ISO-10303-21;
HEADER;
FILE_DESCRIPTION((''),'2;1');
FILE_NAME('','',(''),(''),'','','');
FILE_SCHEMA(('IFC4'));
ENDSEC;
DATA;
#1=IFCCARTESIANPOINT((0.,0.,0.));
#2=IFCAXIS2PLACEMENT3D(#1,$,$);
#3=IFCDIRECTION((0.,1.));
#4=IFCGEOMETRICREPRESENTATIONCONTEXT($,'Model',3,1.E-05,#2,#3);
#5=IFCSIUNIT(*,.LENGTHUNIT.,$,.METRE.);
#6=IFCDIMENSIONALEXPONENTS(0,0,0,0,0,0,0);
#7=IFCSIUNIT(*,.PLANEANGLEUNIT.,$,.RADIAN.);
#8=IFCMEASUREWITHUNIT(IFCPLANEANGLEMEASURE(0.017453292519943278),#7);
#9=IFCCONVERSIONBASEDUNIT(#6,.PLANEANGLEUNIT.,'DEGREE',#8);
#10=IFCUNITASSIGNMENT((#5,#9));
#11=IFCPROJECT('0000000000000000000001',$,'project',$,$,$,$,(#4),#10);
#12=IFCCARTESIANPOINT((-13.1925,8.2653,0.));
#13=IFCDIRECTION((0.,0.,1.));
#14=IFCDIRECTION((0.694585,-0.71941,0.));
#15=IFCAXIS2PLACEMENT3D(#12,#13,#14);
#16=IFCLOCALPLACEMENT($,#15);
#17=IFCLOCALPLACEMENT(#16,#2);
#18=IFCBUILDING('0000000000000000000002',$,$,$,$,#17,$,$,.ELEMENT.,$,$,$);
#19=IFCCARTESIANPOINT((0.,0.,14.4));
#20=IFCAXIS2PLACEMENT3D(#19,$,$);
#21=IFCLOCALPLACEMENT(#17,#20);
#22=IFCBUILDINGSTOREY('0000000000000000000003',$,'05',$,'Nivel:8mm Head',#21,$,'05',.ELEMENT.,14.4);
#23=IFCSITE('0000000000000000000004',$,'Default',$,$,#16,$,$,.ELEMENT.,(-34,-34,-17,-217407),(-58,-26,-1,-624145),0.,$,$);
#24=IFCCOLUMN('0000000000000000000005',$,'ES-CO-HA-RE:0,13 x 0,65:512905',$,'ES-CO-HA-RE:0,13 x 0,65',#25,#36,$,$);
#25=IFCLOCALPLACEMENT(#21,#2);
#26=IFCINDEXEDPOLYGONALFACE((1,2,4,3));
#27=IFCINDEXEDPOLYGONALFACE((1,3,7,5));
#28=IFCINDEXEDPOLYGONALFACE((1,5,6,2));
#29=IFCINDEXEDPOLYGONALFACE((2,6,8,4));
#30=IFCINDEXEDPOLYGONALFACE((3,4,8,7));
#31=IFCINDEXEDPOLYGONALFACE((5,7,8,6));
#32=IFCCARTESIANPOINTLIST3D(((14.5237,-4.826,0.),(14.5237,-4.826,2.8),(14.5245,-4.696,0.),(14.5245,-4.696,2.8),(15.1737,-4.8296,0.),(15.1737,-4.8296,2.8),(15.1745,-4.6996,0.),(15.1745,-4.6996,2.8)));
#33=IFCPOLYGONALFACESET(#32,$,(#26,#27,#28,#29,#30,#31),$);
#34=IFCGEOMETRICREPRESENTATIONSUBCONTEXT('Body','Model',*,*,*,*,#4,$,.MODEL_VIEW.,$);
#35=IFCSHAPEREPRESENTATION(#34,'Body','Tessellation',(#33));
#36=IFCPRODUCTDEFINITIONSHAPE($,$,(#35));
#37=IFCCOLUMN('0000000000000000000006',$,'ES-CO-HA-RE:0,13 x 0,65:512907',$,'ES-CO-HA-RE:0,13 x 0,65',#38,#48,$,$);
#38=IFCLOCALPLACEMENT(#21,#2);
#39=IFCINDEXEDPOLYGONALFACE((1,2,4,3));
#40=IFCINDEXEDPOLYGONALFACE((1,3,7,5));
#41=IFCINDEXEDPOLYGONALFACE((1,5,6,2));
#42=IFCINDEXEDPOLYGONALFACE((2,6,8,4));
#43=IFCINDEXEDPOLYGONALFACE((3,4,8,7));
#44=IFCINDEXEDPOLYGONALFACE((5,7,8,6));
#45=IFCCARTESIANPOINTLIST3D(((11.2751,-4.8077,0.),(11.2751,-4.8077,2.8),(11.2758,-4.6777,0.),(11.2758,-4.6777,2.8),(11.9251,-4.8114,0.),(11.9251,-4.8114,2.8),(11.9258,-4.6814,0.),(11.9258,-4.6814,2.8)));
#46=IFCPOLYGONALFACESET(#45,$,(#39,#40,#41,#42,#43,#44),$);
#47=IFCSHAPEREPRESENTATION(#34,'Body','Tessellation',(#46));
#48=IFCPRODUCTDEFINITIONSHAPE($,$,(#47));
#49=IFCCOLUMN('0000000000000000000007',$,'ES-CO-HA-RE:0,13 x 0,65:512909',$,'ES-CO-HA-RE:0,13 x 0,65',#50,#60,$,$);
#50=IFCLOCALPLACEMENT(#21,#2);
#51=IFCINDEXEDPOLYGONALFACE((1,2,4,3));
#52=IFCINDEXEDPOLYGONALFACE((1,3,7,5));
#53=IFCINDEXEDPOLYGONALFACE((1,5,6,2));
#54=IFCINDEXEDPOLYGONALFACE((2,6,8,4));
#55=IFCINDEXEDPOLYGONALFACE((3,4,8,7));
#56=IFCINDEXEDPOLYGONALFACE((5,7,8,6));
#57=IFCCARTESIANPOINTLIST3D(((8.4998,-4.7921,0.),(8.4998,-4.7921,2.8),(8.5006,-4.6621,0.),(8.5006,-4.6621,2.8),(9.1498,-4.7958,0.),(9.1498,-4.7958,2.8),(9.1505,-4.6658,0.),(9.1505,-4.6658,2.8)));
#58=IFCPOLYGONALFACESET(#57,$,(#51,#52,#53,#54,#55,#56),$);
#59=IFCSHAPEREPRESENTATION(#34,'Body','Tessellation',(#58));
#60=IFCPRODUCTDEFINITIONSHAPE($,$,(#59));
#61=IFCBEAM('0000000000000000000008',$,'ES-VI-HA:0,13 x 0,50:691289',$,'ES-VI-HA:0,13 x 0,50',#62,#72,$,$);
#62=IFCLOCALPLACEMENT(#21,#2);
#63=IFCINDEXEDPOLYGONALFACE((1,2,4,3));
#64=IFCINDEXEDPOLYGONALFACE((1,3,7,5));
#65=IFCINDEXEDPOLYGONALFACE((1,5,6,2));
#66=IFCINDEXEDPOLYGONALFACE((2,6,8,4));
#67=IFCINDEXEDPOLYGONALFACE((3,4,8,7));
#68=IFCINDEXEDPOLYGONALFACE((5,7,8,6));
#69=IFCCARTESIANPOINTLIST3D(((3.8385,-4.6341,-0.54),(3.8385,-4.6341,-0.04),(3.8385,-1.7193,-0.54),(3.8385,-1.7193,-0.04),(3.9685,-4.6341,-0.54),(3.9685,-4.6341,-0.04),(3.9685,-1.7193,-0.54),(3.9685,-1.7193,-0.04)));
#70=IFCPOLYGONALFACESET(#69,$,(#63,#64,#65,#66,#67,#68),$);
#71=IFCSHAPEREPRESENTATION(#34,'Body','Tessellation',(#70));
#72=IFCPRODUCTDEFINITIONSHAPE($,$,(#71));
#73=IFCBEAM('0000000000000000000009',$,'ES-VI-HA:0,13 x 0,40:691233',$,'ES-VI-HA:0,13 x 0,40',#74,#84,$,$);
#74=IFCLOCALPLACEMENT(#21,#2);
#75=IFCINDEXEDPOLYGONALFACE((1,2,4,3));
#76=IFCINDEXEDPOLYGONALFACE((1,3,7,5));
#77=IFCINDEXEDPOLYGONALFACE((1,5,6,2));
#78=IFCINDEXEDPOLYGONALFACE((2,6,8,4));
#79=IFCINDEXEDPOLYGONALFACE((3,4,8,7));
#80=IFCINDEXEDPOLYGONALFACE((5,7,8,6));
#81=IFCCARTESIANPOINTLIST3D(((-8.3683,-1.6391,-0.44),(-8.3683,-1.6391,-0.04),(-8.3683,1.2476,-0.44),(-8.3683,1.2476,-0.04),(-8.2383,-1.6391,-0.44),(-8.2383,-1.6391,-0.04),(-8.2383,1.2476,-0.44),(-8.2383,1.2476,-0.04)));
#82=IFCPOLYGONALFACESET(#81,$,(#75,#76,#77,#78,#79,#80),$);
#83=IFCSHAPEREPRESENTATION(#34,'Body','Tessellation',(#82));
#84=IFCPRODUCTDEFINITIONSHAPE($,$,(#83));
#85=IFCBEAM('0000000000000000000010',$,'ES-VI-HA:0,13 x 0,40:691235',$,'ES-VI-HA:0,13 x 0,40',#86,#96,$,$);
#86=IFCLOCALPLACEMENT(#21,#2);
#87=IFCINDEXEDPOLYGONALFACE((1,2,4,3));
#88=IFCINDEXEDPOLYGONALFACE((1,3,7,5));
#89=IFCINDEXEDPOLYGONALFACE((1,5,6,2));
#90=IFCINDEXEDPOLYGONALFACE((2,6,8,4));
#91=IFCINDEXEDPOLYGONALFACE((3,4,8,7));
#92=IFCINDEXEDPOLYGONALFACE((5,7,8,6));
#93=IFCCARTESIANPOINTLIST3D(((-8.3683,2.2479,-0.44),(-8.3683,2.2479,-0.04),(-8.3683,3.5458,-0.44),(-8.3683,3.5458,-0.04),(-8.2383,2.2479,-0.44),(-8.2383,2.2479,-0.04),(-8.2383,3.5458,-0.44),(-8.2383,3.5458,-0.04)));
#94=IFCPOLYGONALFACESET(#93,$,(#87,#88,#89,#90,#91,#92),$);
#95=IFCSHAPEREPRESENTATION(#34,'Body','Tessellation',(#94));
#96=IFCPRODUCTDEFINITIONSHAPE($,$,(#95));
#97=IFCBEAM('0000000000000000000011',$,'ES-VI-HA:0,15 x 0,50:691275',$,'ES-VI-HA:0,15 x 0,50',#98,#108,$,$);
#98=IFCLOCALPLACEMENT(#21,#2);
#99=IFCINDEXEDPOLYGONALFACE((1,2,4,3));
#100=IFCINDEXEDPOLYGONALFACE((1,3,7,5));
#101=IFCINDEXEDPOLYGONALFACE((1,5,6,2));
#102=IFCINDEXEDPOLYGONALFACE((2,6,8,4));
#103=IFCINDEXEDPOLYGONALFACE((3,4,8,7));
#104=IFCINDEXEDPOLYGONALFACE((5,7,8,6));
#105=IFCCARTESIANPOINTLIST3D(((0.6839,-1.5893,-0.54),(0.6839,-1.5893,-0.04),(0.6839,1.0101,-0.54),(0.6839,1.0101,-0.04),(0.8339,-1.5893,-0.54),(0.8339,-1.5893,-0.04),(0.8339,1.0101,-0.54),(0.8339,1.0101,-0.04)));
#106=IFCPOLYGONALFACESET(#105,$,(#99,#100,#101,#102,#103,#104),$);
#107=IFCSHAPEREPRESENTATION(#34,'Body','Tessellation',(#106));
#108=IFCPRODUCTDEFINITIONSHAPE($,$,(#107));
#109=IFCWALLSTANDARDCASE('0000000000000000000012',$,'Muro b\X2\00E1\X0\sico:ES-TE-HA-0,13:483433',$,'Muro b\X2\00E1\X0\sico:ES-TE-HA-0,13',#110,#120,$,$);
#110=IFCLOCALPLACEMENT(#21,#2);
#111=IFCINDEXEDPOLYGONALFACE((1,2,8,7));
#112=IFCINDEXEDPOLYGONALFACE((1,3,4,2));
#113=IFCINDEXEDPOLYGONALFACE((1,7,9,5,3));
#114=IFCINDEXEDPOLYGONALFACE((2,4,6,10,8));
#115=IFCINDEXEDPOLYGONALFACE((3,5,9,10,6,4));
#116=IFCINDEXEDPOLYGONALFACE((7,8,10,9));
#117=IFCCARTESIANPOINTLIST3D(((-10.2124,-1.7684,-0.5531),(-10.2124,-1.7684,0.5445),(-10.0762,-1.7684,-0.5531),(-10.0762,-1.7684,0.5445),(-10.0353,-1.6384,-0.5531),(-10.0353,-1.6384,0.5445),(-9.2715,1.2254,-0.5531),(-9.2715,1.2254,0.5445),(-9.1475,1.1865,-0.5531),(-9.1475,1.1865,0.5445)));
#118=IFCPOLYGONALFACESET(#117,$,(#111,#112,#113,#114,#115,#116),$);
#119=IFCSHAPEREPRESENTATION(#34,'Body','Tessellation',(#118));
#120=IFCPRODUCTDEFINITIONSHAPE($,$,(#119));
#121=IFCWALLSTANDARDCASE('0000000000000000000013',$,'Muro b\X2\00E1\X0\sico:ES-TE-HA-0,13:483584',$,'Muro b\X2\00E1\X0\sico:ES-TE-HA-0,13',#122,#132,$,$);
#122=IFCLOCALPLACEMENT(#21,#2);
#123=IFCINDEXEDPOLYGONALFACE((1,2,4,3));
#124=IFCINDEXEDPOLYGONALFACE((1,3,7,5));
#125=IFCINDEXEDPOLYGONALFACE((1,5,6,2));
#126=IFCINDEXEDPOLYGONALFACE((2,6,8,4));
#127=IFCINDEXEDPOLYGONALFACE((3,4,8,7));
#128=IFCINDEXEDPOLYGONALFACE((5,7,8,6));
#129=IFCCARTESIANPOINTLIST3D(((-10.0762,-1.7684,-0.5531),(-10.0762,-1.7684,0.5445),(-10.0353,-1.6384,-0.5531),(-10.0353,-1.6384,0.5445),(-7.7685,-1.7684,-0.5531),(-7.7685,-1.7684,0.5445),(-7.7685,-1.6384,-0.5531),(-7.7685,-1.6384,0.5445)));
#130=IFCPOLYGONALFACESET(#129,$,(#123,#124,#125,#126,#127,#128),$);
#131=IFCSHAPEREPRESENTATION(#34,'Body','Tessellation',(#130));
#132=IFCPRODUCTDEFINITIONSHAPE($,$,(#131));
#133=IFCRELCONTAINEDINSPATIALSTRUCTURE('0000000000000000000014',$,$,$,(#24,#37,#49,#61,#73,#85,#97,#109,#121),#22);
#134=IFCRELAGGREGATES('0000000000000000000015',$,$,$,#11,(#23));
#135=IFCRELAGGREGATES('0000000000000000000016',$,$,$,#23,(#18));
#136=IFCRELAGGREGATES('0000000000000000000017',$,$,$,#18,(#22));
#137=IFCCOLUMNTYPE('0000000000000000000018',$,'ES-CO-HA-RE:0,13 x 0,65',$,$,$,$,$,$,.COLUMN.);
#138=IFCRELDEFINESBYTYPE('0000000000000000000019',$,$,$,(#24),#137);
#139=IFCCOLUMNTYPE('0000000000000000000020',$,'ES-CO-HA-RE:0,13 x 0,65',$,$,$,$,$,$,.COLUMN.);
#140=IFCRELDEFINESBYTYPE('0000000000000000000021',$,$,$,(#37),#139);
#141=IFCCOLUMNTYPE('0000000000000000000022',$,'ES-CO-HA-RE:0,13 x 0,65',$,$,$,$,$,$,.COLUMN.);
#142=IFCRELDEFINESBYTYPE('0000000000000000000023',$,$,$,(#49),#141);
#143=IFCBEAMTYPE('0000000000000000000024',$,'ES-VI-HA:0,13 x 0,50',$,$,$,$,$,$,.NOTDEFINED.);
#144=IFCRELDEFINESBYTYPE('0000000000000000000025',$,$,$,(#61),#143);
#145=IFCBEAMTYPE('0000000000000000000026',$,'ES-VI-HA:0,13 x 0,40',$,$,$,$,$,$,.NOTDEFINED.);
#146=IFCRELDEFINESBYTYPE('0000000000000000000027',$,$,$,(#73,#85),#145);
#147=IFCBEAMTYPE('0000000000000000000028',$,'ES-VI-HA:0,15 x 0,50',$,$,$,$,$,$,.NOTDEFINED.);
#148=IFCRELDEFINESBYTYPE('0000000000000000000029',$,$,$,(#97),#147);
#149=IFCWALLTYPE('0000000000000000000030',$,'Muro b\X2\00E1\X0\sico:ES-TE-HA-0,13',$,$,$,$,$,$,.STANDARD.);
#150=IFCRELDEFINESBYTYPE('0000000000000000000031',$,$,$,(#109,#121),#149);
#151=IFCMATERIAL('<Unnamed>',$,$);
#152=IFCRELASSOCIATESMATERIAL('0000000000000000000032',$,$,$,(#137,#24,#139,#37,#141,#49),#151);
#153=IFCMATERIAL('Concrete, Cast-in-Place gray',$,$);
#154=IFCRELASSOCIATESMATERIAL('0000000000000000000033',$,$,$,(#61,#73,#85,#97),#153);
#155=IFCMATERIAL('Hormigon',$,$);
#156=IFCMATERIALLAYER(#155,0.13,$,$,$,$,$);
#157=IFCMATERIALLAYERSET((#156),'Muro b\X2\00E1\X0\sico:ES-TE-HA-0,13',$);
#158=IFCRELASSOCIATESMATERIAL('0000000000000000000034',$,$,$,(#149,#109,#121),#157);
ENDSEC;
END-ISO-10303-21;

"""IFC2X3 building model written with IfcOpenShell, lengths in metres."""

from ifc_helpers import new_model, entity, si_unit, converted_unit, direction, frame, frame_2d, origin, origin_2d_with_axis, place, context, subcontext, project, spatial, polyline, rectangle, outline, extrude, source, transform, mapped, material, layer, layer_set, layer_usage, type_object, type_shapes, element, save


model = new_model("IFC2X3")

# Units and contexts
model_context = context("Model", 3, precision=1e-05, world=origin(), true_north=direction((0.0, 1.0)))
body_context = subcontext(model_context, "Body", "Model", "MODEL_VIEW")
ifc_project = project(units=[si_unit("LENGTHUNIT", "METRE"), converted_unit("PLANEANGLEUNIT", "DEGREE", entity("IfcPlaneAngleMeasure", 0.017453292519943278), si_unit("PLANEANGLEUNIT", "RADIAN"), dimensions=[0, 0, 0, 0, 0, 0, 0])], contexts=[model_context])

# Site, building, storey
site_placement = place(None, frame((-13.1925, 8.2653, 0.0), z_axis=(0.0, 0.0, 1.0), x_axis=(0.694585, -0.71941, 0.0)))
site = spatial("IfcSite", under=ifc_project, at=site_placement, Name="Default", CompositionType="ELEMENT", RefLatitude=(-34, -34, -17, -217407), RefLongitude=(-58, -26, -1, -624145), RefElevation=0.0)
building_placement = place(site_placement, origin())
building = spatial("IfcBuilding", under=site, at=building_placement, CompositionType="ELEMENT")
storey_placement = place(building_placement, frame((0.0, 0.0, 14.4)))
storey = spatial("IfcBuildingStorey", under=building, at=storey_placement, Name="05", ObjectType="Nivel:8mm Head", LongName="05", CompositionType="ELEMENT", Elevation=14.4)

# Columns
ifc_material_1 = material(Name="<Unnamed>")
column_type_1 = type_object("IfcColumnType", Name="ES-CO-HA-RE:0,13 x 0,65", PredefinedType="COLUMN", material=ifc_material_1)
shared_shape_1 = source(origin(), body_context, "Body", "SweptSolid", [
    extrude(rectangle(XDim=0.65, YDim=0.13, at=frame_2d((0.0, 0.0), x_axis=(1.0, 0.0))), frame((14.8491, -4.7628, 14.4), z_axis=(0.0, 0.0, 1.0), x_axis=(-0.999984, 0.005619, 0.0)), (0.0, 0.0, 1.0), 2.8),
])
type_shapes(column_type_1, [shared_shape_1])
column_1_placement = place(storey_placement, frame((0.0, 0.0, -14.4)))
element("IfcColumn", 1, at=column_1_placement, inside=storey, type_object=column_type_1, material=ifc_material_1, Name="ES-CO-HA-RE:0,13 x 0,65:512905", ObjectType="ES-CO-HA-RE:0,13 x 0,65", context=body_context, shape_type="MappedRepresentation", body=[
    mapped(shared_shape_1, transform((0.0, 0.0, 0.0), scale=1.0)),
])
column_type_2 = type_object("IfcColumnType", Name="ES-CO-HA-RE:0,13 x 0,65", PredefinedType="COLUMN", material=ifc_material_1)
shared_shape_2 = source(origin(), body_context, "Body", "SweptSolid", [
    extrude(rectangle(XDim=0.65, YDim=0.13, at=frame_2d((0.0, 0.0), x_axis=(1.0, 0.0))), frame((11.6005, -4.7445, 14.4), z_axis=(0.0, 0.0, 1.0), x_axis=(-0.999984, 0.005619, 0.0)), (0.0, 0.0, 1.0), 2.8),
])
type_shapes(column_type_2, [shared_shape_2])
column_2_placement = place(storey_placement, frame((0.0, 0.0, -14.4)))
element("IfcColumn", 2, at=column_2_placement, inside=storey, type_object=column_type_2, material=ifc_material_1, Name="ES-CO-HA-RE:0,13 x 0,65:512907", ObjectType="ES-CO-HA-RE:0,13 x 0,65", context=body_context, shape_type="MappedRepresentation", body=[
    mapped(shared_shape_2, transform((0.0, 0.0, 0.0), scale=1.0)),
])
column_type_3 = type_object("IfcColumnType", Name="ES-CO-HA-RE:0,13 x 0,65", PredefinedType="COLUMN", material=ifc_material_1)
shared_shape_3 = source(origin(), body_context, "Body", "SweptSolid", [
    extrude(rectangle(XDim=0.65, YDim=0.13, at=origin_2d_with_axis()), frame((8.8252, -4.7289, 14.4), z_axis=(0.0, 0.0, 1.0), x_axis=(-0.999984, 0.005619, 0.0)), (0.0, 0.0, 1.0), 2.8),
])
type_shapes(column_type_3, [shared_shape_3])
column_3_placement = place(storey_placement, frame((0.0, 0.0, -14.4)))
element("IfcColumn", 3, at=column_3_placement, inside=storey, type_object=column_type_3, material=ifc_material_1, Name="ES-CO-HA-RE:0,13 x 0,65:512909", ObjectType="ES-CO-HA-RE:0,13 x 0,65", context=body_context, shape_type="MappedRepresentation", body=[
    mapped(shared_shape_3, transform((0.0, 0.0, 0.0), scale=1.0)),
])

# Beams
ifc_material_2 = material(Name="Concrete, Cast-in-Place gray")
beam_type_1 = type_object("IfcBeamType", Name="ES-VI-HA:0,13 x 0,50", PredefinedType="NOTDEFINED")
beam_1_placement = place(storey_placement, frame((3.9035, -4.7011, -0.04), z_axis=(0.0, 0.0, 1.0), x_axis=(0.0, 1.0, 0.0)))
element("IfcBeam", 4, at=beam_1_placement, inside=storey, type_object=beam_type_1, material=ifc_material_2, Name="ES-VI-HA:0,13 x 0,50:691289", ObjectType="ES-VI-HA:0,13 x 0,50", context=body_context, shape_type="SweptSolid", body=[
    extrude(rectangle(XDim=0.5, YDim=0.13, at=frame_2d((0.0, 0.0), x_axis=(1.0, 0.0))), frame((0.067, 0.0, -0.25), z_axis=(1.0, 0.0, 0.0), x_axis=(0.0, 0.0, -1.0)), (0.0, 0.0, 1.0), 2.9148),
])
beam_type_2 = type_object("IfcBeamType", Name="ES-VI-HA:0,13 x 0,40", PredefinedType="NOTDEFINED")
beam_2_placement = place(storey_placement, frame((-8.3033, -1.6391, -0.04), z_axis=(0.0, 0.0, 1.0), x_axis=(0.0, 1.0, 0.0)))
element("IfcBeam", 5, at=beam_2_placement, inside=storey, type_object=beam_type_2, material=ifc_material_2, Name="ES-VI-HA:0,13 x 0,40:691233", ObjectType="ES-VI-HA:0,13 x 0,40", context=body_context, shape_type="SweptSolid", body=[
    extrude(rectangle(XDim=0.4, YDim=0.13, at=frame_2d((0.0, 0.0), x_axis=(1.0, 0.0))), frame((0.0, 0.0, -0.2), z_axis=(1.0, 0.0, 0.0), x_axis=(0.0, 0.0, -1.0)), (0.0, 0.0, 1.0), 2.8867),
])
beam_3_placement = place(storey_placement, frame((-8.3033, 2.2479, -0.04), z_axis=(0.0, 0.0, 1.0), x_axis=(0.0, 1.0, 0.0)))
element("IfcBeam", 6, at=beam_3_placement, inside=storey, type_object=beam_type_2, material=ifc_material_2, Name="ES-VI-HA:0,13 x 0,40:691235", ObjectType="ES-VI-HA:0,13 x 0,40", context=body_context, shape_type="SweptSolid", body=[
    extrude(rectangle(XDim=0.4, YDim=0.13, at=frame_2d((0.0, 0.0), x_axis=(1.0, 0.0))), frame((0.0, 0.0, -0.2), z_axis=(1.0, 0.0, 0.0), x_axis=(0.0, 0.0, -1.0)), (0.0, 0.0, 1.0), 1.298),
])
beam_type_3 = type_object("IfcBeamType", Name="ES-VI-HA:0,15 x 0,50", PredefinedType="NOTDEFINED")
beam_4_placement = place(storey_placement, frame((0.7589, -1.6543, -0.04), z_axis=(0.0, 0.0, 1.0), x_axis=(0.0, 1.0, 0.0)))
element("IfcBeam", 7, at=beam_4_placement, inside=storey, type_object=beam_type_3, material=ifc_material_2, Name="ES-VI-HA:0,15 x 0,50:691275", ObjectType="ES-VI-HA:0,15 x 0,50", context=body_context, shape_type="SweptSolid", body=[
    extrude(rectangle(XDim=0.5, YDim=0.15, at=frame_2d((0.0, 0.0), x_axis=(1.0, 0.0))), frame((0.065, 0.0, -0.25), z_axis=(1.0, 0.0, 0.0), x_axis=(0.0, 0.0, -1.0)), (0.0, 0.0, 1.0), 2.5994),
])

# Shared definitions
ifc_material_3 = material(Name="Hormigon")

# Walls
ifc_layer_1 = layer(ifc_material_3, 0.13)
ifc_layer_set_1 = layer_set([ifc_layer_1], Name="Muro básico:ES-TE-HA-0,13")
ifc_layer_usage_1 = layer_usage(ifc_layer_set_1, "AXIS2", "NEGATIVE", 0.065)
wall_type = type_object("IfcWallType", Name="Muro básico:ES-TE-HA-0,13", PredefinedType="STANDARD", material=ifc_layer_set_1)
wall_1_placement = place(storey_placement, frame((-10.1504, -1.7879, -0.5531), z_axis=(0.0, 0.0, 1.0), x_axis=(0.299835, 0.953991, 0.0)))
element("IfcWallStandardCase", 8, at=wall_1_placement, inside=storey, type_object=wall_type, material=ifc_layer_usage_1, Name="Muro básico:ES-TE-HA-0,13:483433", ObjectType="Muro básico:ES-TE-HA-0,13", context=body_context, shape_type="SweptSolid", body=[
    extrude(outline(polyline([(3.1382, -0.065), (3.1382, 0.065), (0.0, 0.065), (0.0409, -0.065), (0.1771, -0.065), (3.1382, -0.065)])), origin(), (0.0, 0.0, 1.0), 1.0976),
])
ifc_layer_usage_2 = layer_usage(ifc_layer_set_1, "AXIS2", "POSITIVE", -0.065)
wall_2_placement = place(storey_placement, frame((-10.0762, -1.7034, -0.5531)))
element("IfcWallStandardCase", 9, at=wall_2_placement, inside=storey, type_object=wall_type, material=ifc_layer_usage_2, Name="Muro básico:ES-TE-HA-0,13:483584", ObjectType="Muro básico:ES-TE-HA-0,13", context=body_context, shape_type="SweptSolid", body=[
    extrude(outline(polyline([(2.3077, -0.065), (2.3077, 0.065), (0.0409, 0.065), (0.0, -0.065), (2.3077, -0.065)])), origin(), (0.0, 0.0, 1.0), 1.0976),
])

save(model, "model.ifc")
